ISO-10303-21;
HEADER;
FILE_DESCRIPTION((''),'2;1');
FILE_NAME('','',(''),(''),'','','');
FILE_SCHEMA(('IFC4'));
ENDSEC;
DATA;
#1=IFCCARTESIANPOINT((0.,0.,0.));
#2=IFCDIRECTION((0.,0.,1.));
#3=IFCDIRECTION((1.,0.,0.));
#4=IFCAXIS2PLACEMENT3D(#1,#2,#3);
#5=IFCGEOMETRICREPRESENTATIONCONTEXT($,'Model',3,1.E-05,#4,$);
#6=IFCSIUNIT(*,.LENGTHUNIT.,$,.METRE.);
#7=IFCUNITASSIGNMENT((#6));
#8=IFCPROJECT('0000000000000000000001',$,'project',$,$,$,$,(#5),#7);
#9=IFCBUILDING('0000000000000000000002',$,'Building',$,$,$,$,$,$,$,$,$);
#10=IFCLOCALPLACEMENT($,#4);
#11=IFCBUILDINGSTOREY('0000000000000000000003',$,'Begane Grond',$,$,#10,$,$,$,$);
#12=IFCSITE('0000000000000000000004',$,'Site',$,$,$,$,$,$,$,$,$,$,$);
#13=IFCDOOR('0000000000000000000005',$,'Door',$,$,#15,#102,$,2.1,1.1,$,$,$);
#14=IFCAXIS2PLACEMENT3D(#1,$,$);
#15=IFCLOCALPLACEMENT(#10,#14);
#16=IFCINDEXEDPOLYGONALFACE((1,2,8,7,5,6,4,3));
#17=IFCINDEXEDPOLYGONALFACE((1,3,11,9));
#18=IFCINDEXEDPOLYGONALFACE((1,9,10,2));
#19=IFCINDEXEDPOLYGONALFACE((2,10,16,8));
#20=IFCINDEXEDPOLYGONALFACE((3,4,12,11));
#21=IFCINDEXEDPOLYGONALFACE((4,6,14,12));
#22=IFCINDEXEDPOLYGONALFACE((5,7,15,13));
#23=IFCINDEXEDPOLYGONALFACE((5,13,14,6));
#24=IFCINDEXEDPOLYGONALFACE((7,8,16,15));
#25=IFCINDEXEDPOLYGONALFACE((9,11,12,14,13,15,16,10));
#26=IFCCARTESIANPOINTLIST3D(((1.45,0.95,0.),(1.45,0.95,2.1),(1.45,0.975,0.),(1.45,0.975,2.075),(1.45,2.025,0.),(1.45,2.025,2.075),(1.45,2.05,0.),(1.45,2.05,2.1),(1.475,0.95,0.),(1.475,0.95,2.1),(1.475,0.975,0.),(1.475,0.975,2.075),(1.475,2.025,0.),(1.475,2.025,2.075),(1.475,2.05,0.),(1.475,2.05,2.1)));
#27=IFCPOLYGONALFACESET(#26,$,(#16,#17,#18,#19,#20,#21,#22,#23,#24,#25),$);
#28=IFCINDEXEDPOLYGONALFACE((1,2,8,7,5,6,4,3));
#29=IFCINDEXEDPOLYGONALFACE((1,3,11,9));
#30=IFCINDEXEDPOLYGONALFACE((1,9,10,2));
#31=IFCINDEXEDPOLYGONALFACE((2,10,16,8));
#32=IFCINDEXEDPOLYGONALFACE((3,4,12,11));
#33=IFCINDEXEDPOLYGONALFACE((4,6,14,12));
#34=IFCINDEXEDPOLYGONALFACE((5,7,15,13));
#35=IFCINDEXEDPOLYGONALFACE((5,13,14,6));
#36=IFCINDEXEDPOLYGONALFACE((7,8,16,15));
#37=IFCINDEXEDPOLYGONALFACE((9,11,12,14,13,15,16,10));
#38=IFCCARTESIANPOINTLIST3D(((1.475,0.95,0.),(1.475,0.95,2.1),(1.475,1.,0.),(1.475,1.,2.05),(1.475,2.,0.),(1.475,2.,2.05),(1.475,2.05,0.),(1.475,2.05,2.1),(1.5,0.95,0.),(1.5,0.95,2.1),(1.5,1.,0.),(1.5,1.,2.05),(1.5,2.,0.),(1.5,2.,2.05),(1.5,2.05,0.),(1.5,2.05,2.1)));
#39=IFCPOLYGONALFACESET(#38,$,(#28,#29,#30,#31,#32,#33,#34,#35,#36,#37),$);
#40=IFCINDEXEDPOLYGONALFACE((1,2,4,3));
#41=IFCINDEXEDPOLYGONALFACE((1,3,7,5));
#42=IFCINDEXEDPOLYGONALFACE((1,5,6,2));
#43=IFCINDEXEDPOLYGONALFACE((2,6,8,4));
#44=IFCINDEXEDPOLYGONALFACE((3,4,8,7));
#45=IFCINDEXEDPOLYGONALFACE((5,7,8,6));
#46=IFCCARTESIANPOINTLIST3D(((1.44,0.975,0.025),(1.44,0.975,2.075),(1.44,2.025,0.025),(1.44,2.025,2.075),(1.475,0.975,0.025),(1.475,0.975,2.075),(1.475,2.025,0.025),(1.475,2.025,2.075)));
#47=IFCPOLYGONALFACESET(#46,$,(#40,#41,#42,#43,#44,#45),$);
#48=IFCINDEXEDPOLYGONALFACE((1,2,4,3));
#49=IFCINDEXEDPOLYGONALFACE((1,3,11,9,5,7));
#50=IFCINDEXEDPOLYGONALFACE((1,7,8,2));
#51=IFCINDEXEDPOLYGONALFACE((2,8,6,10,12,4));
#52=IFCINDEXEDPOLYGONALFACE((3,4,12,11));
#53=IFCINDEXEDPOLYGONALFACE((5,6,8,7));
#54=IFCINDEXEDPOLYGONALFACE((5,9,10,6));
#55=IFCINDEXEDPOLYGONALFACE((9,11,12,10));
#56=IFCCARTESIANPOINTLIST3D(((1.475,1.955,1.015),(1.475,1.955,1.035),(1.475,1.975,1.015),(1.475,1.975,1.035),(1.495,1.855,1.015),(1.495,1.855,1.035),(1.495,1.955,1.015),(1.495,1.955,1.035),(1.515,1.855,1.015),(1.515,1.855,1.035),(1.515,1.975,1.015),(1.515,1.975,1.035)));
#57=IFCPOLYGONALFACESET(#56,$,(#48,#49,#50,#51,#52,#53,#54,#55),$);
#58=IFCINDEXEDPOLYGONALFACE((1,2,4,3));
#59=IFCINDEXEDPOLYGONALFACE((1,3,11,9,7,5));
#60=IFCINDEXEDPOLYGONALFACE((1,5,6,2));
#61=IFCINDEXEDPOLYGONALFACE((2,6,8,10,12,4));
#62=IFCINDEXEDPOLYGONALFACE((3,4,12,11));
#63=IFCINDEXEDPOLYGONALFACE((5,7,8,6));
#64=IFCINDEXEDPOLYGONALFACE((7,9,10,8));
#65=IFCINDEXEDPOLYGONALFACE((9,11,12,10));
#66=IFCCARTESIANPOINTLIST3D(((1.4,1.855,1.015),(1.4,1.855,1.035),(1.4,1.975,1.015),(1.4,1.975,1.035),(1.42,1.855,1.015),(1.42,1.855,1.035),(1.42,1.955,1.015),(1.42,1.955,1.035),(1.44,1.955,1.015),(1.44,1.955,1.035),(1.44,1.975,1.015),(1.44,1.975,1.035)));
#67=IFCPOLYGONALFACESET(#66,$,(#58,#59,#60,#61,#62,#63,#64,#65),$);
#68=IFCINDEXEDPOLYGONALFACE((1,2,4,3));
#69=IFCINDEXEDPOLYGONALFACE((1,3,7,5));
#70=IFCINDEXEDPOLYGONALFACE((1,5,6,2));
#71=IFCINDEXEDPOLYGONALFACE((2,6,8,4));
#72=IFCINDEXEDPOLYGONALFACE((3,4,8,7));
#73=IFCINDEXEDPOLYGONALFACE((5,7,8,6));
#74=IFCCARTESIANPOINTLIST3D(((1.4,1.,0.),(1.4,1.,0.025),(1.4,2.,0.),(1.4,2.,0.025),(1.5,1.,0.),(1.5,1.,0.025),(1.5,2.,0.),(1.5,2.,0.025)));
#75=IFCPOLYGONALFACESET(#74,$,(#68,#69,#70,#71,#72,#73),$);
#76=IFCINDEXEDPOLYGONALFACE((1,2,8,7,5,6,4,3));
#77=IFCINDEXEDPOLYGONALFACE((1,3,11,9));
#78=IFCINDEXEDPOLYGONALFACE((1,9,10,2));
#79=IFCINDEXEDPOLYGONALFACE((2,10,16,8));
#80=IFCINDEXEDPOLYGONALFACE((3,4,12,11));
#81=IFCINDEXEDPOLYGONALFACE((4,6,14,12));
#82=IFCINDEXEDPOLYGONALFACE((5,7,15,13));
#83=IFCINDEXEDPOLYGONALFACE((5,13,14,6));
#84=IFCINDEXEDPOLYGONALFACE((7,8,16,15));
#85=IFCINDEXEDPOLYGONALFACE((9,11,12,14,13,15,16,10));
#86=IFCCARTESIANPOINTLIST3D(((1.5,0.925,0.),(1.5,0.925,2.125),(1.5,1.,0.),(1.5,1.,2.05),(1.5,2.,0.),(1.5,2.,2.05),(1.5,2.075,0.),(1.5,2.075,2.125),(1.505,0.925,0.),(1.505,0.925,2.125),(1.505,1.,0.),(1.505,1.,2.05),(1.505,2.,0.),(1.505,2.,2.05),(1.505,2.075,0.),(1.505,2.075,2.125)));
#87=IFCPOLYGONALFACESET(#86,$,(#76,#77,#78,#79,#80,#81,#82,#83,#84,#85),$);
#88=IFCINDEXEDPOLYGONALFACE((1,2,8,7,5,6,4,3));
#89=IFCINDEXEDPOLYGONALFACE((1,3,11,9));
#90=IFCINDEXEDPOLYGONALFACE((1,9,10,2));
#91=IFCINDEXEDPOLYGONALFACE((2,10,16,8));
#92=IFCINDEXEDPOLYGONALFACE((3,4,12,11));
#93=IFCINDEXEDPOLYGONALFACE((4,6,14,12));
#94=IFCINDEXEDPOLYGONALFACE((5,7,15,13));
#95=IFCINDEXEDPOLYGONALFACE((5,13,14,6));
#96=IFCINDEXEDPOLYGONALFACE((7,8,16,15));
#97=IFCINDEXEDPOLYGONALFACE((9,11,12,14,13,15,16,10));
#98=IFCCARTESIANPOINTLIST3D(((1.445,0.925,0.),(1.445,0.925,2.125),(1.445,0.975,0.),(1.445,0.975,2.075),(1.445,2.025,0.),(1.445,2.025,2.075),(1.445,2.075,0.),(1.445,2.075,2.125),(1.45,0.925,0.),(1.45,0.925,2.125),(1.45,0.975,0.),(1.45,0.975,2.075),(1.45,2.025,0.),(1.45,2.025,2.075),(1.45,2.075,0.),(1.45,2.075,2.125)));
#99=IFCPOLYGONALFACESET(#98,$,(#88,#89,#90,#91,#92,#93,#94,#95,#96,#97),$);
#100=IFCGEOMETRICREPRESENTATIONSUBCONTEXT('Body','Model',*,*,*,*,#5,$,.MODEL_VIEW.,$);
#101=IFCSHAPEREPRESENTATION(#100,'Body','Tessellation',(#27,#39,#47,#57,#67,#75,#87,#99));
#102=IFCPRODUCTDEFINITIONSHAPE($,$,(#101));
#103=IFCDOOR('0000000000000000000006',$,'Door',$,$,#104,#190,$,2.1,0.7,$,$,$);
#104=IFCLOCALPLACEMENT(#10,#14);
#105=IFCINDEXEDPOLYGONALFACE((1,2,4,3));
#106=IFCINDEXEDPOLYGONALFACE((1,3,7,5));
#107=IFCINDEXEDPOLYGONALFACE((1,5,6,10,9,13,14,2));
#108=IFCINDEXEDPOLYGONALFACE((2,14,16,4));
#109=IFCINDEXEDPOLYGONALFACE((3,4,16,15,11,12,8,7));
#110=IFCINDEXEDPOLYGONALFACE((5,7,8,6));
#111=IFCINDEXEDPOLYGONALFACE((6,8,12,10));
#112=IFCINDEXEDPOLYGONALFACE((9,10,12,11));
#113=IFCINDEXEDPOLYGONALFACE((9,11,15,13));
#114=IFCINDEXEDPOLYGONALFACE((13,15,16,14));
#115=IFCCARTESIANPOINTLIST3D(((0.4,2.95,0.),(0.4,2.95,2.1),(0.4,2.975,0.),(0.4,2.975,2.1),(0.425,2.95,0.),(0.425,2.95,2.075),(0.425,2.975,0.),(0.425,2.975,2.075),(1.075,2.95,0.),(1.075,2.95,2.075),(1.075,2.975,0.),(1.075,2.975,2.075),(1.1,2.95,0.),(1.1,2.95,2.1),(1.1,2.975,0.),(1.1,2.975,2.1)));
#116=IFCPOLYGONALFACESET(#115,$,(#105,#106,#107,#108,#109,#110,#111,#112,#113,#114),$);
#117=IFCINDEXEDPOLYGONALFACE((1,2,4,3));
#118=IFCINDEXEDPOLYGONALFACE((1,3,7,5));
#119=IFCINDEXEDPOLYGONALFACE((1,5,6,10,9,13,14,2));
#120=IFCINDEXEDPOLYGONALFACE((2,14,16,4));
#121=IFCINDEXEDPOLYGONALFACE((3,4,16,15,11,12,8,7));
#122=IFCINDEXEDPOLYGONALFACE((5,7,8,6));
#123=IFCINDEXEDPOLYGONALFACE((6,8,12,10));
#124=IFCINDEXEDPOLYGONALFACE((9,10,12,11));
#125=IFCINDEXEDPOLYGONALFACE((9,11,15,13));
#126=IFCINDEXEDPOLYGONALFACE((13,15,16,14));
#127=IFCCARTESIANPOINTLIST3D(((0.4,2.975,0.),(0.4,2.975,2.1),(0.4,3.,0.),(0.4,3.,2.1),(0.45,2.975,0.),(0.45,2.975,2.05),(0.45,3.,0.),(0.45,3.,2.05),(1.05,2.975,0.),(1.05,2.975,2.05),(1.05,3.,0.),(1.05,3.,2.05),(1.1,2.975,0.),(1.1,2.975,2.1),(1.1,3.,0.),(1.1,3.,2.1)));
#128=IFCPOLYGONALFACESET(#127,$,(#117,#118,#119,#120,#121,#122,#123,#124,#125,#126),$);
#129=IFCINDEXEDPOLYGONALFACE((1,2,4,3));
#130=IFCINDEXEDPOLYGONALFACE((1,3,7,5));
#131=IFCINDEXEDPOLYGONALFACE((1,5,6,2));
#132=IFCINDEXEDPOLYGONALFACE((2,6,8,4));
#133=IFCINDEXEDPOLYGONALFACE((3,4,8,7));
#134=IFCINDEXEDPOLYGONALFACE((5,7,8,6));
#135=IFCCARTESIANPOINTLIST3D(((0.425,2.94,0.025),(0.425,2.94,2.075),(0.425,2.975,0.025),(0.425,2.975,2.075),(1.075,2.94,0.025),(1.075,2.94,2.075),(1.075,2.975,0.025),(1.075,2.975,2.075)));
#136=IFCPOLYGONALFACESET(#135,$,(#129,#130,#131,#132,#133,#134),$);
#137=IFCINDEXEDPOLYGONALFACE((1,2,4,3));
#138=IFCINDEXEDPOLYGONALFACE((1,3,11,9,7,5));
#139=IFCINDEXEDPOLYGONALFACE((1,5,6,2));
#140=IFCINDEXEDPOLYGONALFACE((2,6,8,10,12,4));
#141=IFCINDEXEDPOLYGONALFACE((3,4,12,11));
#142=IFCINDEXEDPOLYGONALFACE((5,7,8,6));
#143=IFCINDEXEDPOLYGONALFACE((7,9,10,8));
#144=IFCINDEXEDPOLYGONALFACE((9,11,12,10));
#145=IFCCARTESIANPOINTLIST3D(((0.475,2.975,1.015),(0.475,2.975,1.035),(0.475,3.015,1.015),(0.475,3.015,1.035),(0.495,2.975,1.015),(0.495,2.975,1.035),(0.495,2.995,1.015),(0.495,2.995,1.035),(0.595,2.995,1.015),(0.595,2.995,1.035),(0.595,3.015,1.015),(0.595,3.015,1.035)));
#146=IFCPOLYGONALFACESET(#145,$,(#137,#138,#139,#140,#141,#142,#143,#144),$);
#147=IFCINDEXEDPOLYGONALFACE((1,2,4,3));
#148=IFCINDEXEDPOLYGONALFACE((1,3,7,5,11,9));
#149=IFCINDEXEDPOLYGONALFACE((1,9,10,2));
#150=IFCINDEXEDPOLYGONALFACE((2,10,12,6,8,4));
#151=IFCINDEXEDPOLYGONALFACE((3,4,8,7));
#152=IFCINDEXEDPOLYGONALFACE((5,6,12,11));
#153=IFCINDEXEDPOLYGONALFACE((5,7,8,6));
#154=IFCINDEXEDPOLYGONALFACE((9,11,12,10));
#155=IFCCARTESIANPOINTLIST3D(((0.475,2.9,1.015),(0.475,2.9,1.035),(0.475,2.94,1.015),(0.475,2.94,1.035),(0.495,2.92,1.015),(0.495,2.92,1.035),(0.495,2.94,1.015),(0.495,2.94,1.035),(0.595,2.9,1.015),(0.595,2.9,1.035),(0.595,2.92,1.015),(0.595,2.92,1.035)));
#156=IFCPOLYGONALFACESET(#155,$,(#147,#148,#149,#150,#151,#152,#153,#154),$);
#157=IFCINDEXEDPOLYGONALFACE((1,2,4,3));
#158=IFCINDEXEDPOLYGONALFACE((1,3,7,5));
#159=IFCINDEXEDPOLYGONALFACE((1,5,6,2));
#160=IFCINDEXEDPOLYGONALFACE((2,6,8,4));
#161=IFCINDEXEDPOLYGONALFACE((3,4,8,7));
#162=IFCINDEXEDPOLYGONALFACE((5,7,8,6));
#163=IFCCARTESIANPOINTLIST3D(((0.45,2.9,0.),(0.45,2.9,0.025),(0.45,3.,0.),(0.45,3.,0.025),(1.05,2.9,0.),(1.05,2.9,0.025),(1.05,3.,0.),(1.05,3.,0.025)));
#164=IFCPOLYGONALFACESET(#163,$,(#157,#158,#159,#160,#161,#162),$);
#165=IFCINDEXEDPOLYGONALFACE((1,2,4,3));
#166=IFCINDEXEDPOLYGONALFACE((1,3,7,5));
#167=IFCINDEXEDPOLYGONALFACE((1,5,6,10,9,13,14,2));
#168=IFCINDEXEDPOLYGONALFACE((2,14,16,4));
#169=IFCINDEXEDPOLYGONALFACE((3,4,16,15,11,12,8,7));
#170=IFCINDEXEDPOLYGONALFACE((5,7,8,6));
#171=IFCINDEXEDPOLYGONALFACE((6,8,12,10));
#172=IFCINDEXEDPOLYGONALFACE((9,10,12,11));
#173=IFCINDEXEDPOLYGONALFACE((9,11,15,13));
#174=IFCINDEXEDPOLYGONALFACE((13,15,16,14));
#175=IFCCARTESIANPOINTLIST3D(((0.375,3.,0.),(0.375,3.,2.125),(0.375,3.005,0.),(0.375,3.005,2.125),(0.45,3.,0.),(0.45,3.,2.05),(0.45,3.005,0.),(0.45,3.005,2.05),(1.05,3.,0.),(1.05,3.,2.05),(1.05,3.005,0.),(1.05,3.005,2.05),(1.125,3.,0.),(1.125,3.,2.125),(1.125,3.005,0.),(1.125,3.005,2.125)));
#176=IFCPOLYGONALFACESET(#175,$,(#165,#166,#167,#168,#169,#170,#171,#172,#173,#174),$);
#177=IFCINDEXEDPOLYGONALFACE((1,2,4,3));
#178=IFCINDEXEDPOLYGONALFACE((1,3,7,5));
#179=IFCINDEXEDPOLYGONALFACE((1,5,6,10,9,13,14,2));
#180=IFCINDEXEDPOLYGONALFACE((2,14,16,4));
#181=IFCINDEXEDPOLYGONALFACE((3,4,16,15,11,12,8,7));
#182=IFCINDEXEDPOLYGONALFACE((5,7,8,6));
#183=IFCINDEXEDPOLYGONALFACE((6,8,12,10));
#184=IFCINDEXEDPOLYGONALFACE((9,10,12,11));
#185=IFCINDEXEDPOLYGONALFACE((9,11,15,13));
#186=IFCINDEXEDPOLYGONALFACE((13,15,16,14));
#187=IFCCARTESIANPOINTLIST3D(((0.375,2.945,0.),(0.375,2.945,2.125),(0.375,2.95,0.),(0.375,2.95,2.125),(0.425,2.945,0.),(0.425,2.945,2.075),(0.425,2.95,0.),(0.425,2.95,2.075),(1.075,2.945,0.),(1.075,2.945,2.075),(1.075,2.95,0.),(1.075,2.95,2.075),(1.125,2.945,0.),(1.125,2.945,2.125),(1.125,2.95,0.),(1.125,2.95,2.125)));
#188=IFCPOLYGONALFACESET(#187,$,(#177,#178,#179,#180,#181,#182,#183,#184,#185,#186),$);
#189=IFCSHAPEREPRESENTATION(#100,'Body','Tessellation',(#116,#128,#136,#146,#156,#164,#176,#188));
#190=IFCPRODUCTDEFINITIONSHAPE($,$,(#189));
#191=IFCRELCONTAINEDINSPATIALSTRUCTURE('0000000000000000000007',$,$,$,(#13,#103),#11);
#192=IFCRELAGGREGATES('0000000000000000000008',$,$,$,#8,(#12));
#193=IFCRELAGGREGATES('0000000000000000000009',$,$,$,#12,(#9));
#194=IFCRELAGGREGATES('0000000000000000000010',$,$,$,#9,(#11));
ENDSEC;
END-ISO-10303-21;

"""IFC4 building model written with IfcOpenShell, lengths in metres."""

from ifc_helpers import new_model, si_unit, frame, origin_with_axes, place, context, subcontext, project, spatial, line, indexed_curve, outline, extrude, element, save


model = new_model("IFC4")

# Units and contexts
model_context = context("Model", 3, precision=1e-05, world=origin_with_axes())
body_context = subcontext(model_context, "Body", "Model", "MODEL_VIEW")
ifc_project = project(units=[si_unit("LENGTHUNIT", "METRE")], contexts=[model_context])

# Site, building, storey
site = spatial("IfcSite", under=ifc_project, Name="Site")
building = spatial("IfcBuilding", under=site, Name="Building")
storey_placement = place(None, origin_with_axes())
storey = spatial("IfcBuildingStorey", under=building, at=storey_placement, Name="Begane Grond")

# Doors
door_1_placement = place(storey_placement, frame((1.5, 0.95, 0.0), z_axis=(0.0, 0.0, 1.0), x_axis=(0.0, 1.0, 0.0)))
element("IfcDoor", 1, at=door_1_placement, inside=storey, Name="Door", OverallHeight=2.1, OverallWidth=1.1, context=body_context, shape_type="SweptSolid", body=[
    extrude(outline(indexed_curve([(0.0, 0.0), (0.0, 2.1), (1.1, 2.1), (1.1, 0.0), (1.075, 0.0), (1.075, 2.075), (0.025, 2.075), (0.025, 0.0)], segments=[line(1, 2, 3, 4, 5, 6, 7, 8, 1)])), frame((0.0, 0.025, 0.0), z_axis=(0.0, -1.0, 0.0), x_axis=(1.0, 0.0, 0.0)), (0.0, 0.0, -1.0), 0.025),
    extrude(outline(indexed_curve([(0.0, 0.0), (0.0, 2.1), (1.1, 2.1), (1.1, 0.0), (1.05, 0.0), (1.05, 2.05), (0.05, 2.05), (0.05, 0.0)], segments=[line(1, 2, 3, 4, 5, 6, 7, 8, 1)])), frame((0.0, 0.0, 0.0), z_axis=(0.0, -1.0, 0.0), x_axis=(1.0, 0.0, 0.0)), (0.0, 0.0, -1.0), 0.025),
    extrude(outline(indexed_curve([(0.0, 0.0), (1.05, 0.0), (1.05, 0.035), (0.0, 0.035)], segments=[line(1, 2, 3, 4, 1)])), frame((0.025, 0.025, 0.025), z_axis=(0.0, 0.0, 1.0), x_axis=(1.0, 0.0, 0.0)), (0.0, 0.0, 1.0), 2.05),
    extrude(outline(indexed_curve([(0.0, 0.0), (0.0, -0.04), (-0.12, -0.04), (-0.12, -0.02), (-0.02, -0.02), (-0.02, 0.0)], segments=[line(1, 2, 3, 4, 5, 6, 1)])), frame((1.025, 0.025, 1.015), z_axis=(0.0, 0.0, 1.0), x_axis=(1.0, 0.0, 0.0)), (0.0, 0.0, 1.0), 0.02),
    extrude(outline(indexed_curve([(0.0, 0.0), (0.0, 0.04), (-0.12, 0.04), (-0.12, 0.02), (-0.02, 0.02), (-0.02, 0.0)], segments=[line(1, 2, 3, 4, 5, 6, 1)])), frame((1.025, 0.06, 1.015), z_axis=(0.0, 0.0, 1.0), x_axis=(1.0, 0.0, 0.0)), (0.0, 0.0, 1.0), 0.02),
    extrude(outline(indexed_curve([(0.0, 0.0), (1.0, 0.0), (1.0, 0.1), (0.0, 0.1)], segments=[line(1, 2, 3, 4, 1)])), frame((0.05, 0.0, 0.0), z_axis=(0.0, 0.0, 1.0), x_axis=(1.0, 0.0, 0.0)), (0.0, 0.0, 1.0), 0.025),
    extrude(outline(indexed_curve([(0.0, 0.0), (0.0, 2.125), (1.15, 2.125), (1.15, 0.0), (1.075, 0.0), (1.075, 2.05), (0.075, 2.05), (0.075, 0.0)], segments=[line(1, 2, 3, 4, 5, 6, 7, 8, 1)])), frame((-0.025, -0.005, 0.0), z_axis=(0.0, -1.0, 0.0), x_axis=(1.0, 0.0, 0.0)), (0.0, 0.0, -1.0), 0.005),
    extrude(outline(indexed_curve([(0.0, 0.0), (0.0, 2.125), (1.15, 2.125), (1.15, 0.0), (1.1, 0.0), (1.1, 2.075), (0.05, 2.075), (0.05, 0.0)], segments=[line(1, 2, 3, 4, 5, 6, 7, 8, 1)])), frame((-0.025, 0.05, 0.0), z_axis=(0.0, -1.0, 0.0), x_axis=(1.0, 0.0, 0.0)), (0.0, 0.0, -1.0), 0.005),
])
door_2_placement = place(storey_placement, frame((1.1, 3.0, 0.0), z_axis=(0.0, 0.0, 1.0), x_axis=(-1.0, 0.0, 0.0)))
element("IfcDoor", 2, at=door_2_placement, inside=storey, Name="Door", OverallHeight=2.1, OverallWidth=0.7, context=body_context, shape_type="SweptSolid", body=[
    extrude(outline(indexed_curve([(0.0, 0.0), (0.0, 2.1), (0.7, 2.1), (0.7, 0.0), (0.675, 0.0), (0.675, 2.075), (0.025, 2.075), (0.025, 0.0)], segments=[line(1, 2, 3, 4, 5, 6, 7, 8, 1)])), frame((0.0, 0.025, 0.0), z_axis=(0.0, -1.0, 0.0), x_axis=(1.0, 0.0, 0.0)), (0.0, 0.0, -1.0), 0.025),
    extrude(outline(indexed_curve([(0.0, 0.0), (0.0, 2.1), (0.7, 2.1), (0.7, 0.0), (0.65, 0.0), (0.65, 2.05), (0.05, 2.05), (0.05, 0.0)], segments=[line(1, 2, 3, 4, 5, 6, 7, 8, 1)])), frame((0.0, 0.0, 0.0), z_axis=(0.0, -1.0, 0.0), x_axis=(1.0, 0.0, 0.0)), (0.0, 0.0, -1.0), 0.025),
    extrude(outline(indexed_curve([(0.0, 0.0), (0.65, 0.0), (0.65, 0.035), (0.0, 0.035)], segments=[line(1, 2, 3, 4, 1)])), frame((0.025, 0.025, 0.025), z_axis=(0.0, 0.0, 1.0), x_axis=(1.0, 0.0, 0.0)), (0.0, 0.0, 1.0), 2.05),
    extrude(outline(indexed_curve([(0.0, 0.0), (0.0, -0.04), (-0.12, -0.04), (-0.12, -0.02), (-0.02, -0.02), (-0.02, 0.0)], segments=[line(1, 2, 3, 4, 5, 6, 1)])), frame((0.625, 0.025, 1.015), z_axis=(0.0, 0.0, 1.0), x_axis=(1.0, 0.0, 0.0)), (0.0, 0.0, 1.0), 0.02),
    extrude(outline(indexed_curve([(0.0, 0.0), (0.0, 0.04), (-0.12, 0.04), (-0.12, 0.02), (-0.02, 0.02), (-0.02, 0.0)], segments=[line(1, 2, 3, 4, 5, 6, 1)])), frame((0.625, 0.06, 1.015), z_axis=(0.0, 0.0, 1.0), x_axis=(1.0, 0.0, 0.0)), (0.0, 0.0, 1.0), 0.02),
    extrude(outline(indexed_curve([(0.0, 0.0), (0.6, 0.0), (0.6, 0.1), (0.0, 0.1)], segments=[line(1, 2, 3, 4, 1)])), frame((0.05, 0.0, 0.0), z_axis=(0.0, 0.0, 1.0), x_axis=(1.0, 0.0, 0.0)), (0.0, 0.0, 1.0), 0.025),
    extrude(outline(indexed_curve([(0.0, 0.0), (0.0, 2.125), (0.75, 2.125), (0.75, 0.0), (0.675, 0.0), (0.675, 2.05), (0.075, 2.05), (0.075, 0.0)], segments=[line(1, 2, 3, 4, 5, 6, 7, 8, 1)])), frame((-0.025, -0.005, 0.0), z_axis=(0.0, -1.0, 0.0), x_axis=(1.0, 0.0, 0.0)), (0.0, 0.0, -1.0), 0.005),
    extrude(outline(indexed_curve([(0.0, 0.0), (0.0, 2.125), (0.75, 2.125), (0.75, 0.0), (0.7, 0.0), (0.7, 2.075), (0.05, 2.075), (0.05, 0.0)], segments=[line(1, 2, 3, 4, 5, 6, 7, 8, 1)])), frame((-0.025, 0.05, 0.0), z_axis=(0.0, -1.0, 0.0), x_axis=(1.0, 0.0, 0.0)), (0.0, 0.0, -1.0), 0.005),
])

save(model, "model.ifc")
